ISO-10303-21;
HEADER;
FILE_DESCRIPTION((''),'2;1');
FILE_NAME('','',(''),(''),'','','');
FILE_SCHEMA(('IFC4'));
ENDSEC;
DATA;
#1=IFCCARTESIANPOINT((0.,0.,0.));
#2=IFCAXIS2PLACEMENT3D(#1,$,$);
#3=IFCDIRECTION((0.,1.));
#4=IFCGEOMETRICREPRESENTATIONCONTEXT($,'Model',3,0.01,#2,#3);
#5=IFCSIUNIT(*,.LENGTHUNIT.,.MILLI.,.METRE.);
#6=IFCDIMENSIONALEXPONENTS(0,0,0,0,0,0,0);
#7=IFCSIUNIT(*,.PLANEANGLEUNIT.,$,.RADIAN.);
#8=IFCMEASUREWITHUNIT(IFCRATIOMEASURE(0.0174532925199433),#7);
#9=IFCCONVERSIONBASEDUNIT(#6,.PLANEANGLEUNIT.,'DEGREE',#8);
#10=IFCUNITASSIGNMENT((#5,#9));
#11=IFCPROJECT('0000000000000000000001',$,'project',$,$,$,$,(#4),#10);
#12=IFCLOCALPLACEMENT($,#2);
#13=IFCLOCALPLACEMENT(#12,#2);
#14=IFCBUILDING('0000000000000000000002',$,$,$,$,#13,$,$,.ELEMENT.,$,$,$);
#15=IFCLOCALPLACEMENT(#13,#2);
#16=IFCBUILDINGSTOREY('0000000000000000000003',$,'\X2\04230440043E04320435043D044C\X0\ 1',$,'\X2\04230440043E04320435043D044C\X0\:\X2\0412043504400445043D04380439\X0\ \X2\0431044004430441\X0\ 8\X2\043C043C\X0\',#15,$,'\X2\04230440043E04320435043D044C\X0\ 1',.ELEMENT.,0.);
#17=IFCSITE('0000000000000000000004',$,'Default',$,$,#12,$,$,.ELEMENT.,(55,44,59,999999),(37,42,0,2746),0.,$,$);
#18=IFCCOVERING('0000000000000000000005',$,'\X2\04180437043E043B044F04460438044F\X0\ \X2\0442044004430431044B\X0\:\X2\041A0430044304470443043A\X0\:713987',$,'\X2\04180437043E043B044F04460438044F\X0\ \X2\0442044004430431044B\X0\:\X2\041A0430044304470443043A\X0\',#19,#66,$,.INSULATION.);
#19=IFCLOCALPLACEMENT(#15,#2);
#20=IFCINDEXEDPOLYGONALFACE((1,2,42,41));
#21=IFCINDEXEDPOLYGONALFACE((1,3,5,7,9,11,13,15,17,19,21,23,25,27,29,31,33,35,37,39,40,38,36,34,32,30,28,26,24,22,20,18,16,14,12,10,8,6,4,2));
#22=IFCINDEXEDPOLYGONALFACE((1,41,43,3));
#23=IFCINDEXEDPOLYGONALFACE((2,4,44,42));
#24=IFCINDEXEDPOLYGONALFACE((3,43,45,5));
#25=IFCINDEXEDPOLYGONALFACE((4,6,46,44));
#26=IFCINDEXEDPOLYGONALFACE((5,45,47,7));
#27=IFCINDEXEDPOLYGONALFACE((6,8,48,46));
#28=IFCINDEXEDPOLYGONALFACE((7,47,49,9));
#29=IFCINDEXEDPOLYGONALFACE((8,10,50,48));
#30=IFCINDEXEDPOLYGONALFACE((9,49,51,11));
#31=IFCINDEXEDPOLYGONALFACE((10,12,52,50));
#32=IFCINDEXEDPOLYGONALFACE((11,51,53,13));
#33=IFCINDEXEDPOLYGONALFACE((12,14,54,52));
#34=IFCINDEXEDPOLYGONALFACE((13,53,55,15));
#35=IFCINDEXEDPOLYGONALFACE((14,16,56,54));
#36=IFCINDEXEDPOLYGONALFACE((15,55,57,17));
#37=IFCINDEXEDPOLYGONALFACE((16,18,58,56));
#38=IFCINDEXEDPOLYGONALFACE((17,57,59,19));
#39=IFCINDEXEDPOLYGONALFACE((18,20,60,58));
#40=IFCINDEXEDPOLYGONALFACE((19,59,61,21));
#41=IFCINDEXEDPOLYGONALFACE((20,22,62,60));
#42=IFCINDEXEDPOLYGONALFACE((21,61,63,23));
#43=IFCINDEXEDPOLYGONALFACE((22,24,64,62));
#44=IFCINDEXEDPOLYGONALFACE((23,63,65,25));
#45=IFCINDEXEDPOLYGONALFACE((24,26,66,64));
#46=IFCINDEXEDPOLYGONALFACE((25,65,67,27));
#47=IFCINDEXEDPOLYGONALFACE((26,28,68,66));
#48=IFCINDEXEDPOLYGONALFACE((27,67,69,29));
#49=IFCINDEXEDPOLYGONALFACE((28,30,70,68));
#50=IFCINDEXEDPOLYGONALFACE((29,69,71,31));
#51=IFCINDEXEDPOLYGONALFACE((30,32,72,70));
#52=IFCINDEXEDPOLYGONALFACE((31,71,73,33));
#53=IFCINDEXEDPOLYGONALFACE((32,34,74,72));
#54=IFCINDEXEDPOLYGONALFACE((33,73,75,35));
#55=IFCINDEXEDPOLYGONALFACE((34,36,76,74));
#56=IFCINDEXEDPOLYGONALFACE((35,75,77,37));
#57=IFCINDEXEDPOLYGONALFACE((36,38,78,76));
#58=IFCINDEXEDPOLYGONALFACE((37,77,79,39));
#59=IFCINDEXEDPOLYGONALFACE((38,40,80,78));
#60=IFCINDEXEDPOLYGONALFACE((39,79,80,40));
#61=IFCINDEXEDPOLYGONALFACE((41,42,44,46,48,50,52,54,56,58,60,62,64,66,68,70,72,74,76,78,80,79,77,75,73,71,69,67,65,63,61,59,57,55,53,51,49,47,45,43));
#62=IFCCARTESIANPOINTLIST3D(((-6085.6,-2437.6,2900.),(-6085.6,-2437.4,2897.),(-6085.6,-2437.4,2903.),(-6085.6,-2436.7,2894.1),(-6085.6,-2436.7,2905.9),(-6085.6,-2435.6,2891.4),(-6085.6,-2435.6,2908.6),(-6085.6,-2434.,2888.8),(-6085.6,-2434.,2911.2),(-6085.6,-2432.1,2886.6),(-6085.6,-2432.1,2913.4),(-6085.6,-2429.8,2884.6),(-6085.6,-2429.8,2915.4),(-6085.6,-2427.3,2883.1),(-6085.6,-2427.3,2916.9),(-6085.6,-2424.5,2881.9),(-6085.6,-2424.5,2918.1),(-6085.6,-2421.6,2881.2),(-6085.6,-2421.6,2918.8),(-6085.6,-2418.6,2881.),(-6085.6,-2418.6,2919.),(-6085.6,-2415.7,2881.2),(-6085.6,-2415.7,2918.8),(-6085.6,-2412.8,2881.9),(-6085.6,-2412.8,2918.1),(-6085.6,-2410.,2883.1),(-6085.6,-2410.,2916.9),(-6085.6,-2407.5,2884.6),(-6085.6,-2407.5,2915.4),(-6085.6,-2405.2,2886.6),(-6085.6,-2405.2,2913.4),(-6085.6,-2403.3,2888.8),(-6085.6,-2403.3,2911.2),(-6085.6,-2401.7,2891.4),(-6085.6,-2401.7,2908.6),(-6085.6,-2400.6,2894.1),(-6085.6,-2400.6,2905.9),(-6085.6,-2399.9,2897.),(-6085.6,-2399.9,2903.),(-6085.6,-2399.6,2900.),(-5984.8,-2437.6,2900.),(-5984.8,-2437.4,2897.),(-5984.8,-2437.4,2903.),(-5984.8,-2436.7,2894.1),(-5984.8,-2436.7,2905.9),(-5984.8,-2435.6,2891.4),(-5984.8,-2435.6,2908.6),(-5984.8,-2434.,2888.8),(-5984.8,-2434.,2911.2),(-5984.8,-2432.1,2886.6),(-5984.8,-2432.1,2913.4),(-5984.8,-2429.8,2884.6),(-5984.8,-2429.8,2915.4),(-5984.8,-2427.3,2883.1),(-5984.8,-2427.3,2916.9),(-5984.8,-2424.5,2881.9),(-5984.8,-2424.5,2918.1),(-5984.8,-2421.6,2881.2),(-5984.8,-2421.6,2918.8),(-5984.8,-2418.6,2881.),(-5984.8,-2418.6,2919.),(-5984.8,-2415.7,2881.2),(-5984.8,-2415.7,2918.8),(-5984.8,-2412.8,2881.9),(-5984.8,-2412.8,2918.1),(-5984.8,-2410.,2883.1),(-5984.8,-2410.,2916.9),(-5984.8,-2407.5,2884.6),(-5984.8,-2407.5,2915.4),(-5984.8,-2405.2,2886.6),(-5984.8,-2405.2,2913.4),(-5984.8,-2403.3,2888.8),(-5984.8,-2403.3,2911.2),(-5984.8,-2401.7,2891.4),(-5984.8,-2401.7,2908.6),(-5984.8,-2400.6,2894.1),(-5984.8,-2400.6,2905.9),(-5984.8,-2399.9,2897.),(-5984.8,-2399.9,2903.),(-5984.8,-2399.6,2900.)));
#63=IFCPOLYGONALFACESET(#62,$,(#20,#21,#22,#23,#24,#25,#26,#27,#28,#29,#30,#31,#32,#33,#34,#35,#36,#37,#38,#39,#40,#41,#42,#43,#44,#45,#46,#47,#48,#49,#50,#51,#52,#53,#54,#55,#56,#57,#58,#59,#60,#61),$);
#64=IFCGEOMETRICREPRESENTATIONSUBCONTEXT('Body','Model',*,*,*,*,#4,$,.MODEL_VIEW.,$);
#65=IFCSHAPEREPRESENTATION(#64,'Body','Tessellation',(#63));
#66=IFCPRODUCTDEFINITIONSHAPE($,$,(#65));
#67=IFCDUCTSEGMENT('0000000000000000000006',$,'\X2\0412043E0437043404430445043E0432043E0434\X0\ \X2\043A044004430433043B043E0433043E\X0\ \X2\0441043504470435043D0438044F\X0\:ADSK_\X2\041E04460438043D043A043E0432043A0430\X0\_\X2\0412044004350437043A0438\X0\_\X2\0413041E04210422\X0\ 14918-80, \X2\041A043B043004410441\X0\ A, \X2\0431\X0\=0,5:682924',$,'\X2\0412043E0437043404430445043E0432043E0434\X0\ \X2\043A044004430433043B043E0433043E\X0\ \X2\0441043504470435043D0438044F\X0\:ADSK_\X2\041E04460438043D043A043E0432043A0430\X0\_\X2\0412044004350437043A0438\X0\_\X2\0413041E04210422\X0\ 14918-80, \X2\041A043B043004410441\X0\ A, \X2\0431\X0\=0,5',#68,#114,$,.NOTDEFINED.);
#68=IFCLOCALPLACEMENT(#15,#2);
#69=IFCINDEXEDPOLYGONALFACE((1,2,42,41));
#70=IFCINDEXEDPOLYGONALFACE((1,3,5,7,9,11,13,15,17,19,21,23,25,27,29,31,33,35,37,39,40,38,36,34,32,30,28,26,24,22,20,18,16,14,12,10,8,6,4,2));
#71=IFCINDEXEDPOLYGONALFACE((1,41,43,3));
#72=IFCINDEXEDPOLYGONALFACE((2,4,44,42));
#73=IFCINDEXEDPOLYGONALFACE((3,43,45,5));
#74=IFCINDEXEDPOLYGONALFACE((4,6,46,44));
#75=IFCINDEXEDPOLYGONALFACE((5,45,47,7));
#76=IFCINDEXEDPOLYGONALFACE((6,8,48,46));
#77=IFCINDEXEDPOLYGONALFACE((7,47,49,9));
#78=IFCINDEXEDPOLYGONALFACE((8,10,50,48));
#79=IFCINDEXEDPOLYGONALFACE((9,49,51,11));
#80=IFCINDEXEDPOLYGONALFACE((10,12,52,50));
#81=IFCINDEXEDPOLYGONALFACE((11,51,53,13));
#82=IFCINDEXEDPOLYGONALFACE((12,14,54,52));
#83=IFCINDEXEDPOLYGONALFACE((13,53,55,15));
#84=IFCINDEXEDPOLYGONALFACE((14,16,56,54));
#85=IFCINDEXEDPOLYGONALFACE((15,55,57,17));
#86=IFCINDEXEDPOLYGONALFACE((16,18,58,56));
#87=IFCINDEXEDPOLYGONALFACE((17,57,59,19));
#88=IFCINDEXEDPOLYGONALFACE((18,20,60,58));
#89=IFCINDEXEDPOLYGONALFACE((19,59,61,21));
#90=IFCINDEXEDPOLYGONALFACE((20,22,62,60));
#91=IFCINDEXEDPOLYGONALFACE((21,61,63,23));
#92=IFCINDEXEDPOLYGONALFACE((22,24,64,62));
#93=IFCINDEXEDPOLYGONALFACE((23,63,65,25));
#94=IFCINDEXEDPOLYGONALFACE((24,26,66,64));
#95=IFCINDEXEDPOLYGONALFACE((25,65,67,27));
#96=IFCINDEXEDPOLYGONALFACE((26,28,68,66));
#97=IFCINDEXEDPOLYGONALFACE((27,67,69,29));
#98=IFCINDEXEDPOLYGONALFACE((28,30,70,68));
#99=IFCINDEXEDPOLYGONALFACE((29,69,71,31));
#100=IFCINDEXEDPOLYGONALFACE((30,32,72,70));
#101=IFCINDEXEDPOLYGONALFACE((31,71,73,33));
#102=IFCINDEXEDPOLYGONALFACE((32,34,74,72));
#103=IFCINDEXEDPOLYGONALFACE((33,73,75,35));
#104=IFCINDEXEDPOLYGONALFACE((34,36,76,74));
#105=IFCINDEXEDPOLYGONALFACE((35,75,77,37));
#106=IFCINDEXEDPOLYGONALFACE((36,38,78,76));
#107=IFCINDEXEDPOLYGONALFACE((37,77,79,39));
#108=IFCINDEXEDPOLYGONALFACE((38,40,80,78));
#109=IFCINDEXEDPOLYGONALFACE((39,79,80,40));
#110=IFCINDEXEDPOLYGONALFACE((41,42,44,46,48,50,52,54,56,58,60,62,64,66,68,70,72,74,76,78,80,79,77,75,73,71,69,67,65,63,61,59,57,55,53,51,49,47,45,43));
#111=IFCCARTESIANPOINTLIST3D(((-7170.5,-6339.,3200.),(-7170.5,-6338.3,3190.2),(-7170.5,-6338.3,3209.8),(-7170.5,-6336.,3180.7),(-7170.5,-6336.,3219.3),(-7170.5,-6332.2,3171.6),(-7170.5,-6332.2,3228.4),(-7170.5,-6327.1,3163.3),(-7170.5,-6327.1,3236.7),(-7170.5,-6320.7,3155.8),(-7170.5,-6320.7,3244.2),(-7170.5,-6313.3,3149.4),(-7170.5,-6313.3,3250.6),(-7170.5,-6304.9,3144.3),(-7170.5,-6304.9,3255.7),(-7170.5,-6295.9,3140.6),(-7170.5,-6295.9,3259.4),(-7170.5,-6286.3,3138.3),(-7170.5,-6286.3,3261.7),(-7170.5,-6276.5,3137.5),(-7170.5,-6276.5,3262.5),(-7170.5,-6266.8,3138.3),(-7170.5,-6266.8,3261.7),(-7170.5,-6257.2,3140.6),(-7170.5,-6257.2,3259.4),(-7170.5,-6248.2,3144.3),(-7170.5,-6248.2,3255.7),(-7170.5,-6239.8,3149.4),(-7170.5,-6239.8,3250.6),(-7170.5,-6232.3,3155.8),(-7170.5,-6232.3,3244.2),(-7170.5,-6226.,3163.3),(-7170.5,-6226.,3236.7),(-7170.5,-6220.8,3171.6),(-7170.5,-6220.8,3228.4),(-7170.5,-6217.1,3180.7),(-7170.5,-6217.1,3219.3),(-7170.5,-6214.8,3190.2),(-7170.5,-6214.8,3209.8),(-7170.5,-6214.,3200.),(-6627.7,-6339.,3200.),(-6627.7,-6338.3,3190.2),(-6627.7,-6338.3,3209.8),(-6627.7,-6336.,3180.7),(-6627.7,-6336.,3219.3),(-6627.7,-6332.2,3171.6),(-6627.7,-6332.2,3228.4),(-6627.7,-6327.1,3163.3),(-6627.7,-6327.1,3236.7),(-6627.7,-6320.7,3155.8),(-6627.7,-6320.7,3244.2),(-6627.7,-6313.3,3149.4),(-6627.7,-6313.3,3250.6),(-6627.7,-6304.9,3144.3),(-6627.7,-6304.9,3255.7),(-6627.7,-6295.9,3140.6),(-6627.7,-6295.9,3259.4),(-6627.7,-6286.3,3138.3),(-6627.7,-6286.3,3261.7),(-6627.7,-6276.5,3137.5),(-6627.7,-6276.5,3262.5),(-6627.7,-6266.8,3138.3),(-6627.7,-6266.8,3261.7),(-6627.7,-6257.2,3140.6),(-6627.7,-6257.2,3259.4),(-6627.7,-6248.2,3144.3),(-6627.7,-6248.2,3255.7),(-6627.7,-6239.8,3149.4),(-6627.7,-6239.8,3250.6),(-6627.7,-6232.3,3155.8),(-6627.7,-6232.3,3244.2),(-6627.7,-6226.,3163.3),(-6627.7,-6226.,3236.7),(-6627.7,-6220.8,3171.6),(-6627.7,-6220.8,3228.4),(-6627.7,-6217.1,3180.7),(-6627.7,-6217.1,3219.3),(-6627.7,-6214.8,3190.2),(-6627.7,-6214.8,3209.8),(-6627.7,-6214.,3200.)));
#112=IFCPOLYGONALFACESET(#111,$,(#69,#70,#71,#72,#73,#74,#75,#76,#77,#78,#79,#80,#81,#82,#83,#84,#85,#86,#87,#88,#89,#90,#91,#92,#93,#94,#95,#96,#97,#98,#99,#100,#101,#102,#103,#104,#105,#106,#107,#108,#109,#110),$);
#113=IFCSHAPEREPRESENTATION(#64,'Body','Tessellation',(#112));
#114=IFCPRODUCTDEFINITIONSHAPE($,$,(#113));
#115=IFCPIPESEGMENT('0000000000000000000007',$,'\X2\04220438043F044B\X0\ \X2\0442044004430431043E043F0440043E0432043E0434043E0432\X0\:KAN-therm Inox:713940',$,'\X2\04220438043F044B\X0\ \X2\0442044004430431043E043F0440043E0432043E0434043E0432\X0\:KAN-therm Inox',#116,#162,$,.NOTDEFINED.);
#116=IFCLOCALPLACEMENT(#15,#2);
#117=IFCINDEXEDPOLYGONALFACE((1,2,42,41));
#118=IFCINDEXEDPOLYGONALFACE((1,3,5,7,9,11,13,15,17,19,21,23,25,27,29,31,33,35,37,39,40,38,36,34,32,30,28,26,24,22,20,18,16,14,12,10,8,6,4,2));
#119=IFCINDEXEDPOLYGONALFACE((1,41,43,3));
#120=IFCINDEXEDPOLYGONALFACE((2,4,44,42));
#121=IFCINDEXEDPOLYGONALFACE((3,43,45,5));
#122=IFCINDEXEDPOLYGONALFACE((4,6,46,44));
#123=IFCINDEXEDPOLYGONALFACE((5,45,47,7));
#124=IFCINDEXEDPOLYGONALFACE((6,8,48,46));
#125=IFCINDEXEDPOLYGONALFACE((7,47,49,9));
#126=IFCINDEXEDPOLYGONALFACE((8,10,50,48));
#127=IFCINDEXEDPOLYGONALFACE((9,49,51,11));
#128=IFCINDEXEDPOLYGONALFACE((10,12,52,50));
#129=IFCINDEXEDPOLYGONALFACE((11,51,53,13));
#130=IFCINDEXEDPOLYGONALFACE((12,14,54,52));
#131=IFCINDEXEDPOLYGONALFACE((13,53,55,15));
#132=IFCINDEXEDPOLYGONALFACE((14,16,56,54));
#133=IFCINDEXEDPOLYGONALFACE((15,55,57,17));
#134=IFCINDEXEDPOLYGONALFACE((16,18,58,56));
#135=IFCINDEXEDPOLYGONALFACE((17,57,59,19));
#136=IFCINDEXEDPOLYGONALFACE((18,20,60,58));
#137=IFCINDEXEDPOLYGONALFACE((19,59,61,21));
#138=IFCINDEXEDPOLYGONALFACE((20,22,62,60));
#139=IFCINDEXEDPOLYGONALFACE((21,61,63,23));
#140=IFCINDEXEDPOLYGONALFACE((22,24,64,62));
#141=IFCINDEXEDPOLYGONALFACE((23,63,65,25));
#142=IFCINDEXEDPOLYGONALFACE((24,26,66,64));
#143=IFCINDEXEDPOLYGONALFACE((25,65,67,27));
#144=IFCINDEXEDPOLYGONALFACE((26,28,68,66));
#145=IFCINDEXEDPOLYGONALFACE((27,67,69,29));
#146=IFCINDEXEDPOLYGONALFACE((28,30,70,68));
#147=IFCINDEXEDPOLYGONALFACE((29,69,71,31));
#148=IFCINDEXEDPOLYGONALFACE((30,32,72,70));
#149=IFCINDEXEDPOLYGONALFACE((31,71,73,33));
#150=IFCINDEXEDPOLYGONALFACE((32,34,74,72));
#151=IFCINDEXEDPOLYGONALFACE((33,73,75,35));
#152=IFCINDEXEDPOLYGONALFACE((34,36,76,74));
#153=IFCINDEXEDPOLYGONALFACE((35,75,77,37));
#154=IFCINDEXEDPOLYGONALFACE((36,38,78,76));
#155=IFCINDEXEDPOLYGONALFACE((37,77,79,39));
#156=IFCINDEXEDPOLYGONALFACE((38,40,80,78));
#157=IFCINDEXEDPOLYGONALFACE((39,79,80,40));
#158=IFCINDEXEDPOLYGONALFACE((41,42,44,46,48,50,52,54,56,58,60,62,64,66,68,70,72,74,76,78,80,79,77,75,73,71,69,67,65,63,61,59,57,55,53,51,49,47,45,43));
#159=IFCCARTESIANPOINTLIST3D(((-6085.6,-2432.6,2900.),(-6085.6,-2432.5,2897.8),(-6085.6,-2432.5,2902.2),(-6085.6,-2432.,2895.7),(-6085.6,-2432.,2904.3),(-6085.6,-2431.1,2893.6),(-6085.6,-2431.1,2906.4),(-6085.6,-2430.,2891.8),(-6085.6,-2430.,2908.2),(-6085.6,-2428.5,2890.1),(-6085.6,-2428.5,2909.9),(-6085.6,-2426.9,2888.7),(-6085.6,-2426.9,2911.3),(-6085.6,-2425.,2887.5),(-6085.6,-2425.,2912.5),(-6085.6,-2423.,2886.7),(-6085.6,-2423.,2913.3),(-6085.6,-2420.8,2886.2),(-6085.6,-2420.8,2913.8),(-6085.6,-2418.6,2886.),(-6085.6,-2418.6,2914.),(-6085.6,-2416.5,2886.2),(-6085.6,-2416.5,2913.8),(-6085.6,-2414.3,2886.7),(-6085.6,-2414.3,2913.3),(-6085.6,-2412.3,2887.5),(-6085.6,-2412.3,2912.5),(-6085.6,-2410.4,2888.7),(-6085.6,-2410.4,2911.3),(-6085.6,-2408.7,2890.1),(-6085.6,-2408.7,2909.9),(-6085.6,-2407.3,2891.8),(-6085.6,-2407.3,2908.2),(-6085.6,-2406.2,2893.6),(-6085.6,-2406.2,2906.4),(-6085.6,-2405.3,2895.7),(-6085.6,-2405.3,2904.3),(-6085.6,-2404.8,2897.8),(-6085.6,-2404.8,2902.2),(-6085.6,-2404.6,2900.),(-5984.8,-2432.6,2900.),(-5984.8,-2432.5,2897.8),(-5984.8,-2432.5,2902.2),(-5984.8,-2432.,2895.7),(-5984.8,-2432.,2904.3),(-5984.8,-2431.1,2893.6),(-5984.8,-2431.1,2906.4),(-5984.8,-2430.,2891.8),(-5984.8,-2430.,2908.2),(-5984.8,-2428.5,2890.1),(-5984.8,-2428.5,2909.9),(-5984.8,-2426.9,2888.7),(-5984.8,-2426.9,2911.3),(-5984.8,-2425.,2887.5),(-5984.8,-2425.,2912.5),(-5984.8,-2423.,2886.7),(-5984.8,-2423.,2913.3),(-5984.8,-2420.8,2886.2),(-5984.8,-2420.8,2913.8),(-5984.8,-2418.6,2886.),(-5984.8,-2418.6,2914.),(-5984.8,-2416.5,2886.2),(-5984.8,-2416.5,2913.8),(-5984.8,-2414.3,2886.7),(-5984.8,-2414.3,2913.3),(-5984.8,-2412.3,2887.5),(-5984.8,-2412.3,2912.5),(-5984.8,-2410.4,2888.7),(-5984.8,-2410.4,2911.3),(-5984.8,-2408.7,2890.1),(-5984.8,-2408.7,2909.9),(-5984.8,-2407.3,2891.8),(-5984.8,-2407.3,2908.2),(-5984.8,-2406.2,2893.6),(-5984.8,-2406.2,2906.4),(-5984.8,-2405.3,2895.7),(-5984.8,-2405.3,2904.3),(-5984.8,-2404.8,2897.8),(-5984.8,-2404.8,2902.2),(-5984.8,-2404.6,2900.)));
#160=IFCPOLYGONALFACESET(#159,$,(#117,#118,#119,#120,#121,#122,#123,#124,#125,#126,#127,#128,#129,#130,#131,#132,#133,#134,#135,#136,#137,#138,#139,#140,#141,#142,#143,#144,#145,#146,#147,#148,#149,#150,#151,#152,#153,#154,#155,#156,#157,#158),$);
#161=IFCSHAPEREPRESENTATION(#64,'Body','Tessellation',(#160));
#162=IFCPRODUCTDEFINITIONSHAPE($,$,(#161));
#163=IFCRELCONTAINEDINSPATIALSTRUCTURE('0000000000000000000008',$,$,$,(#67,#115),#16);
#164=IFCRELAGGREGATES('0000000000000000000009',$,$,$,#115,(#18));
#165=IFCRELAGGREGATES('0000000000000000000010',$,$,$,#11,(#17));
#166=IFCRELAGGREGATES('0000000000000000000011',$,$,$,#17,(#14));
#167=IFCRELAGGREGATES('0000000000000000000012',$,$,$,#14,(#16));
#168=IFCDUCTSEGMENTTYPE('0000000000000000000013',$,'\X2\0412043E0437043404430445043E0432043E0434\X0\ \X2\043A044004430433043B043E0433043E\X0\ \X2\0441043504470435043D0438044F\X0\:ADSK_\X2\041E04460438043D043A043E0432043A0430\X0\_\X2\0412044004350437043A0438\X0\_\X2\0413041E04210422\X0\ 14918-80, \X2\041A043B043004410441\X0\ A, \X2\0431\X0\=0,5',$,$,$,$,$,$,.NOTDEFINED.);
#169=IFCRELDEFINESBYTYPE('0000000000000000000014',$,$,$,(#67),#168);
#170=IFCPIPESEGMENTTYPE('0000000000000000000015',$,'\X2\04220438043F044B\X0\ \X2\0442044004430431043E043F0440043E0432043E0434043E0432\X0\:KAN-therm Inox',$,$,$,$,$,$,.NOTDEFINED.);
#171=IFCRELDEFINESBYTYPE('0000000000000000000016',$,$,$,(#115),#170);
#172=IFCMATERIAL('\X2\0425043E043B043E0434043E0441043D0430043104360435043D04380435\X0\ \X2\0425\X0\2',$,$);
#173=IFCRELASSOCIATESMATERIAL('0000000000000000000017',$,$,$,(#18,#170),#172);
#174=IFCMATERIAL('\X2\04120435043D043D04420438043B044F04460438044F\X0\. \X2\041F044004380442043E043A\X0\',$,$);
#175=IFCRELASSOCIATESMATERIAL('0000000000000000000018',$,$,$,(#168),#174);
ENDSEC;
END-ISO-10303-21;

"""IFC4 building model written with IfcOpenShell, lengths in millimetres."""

from ifc_helpers import new_model, entity, si_unit, converted_unit, direction, frame, origin, place, context, subcontext, project, spatial, indexed_curve, outline, extrude, material, type_object, element, aggregate, save


model = new_model("IFC4")

# Units and contexts
model_context = context("Model", 3, precision=0.01, world=origin(), true_north=direction((0.0, 1.0)))
body_context = subcontext(model_context, "Body", "Model", "MODEL_VIEW")
ifc_project = project(units=[si_unit("LENGTHUNIT", "METRE", prefix="MILLI"), converted_unit("PLANEANGLEUNIT", "DEGREE", entity("IfcRatioMeasure", 0.0174532925199433), si_unit("PLANEANGLEUNIT", "RADIAN"), dimensions=[0, 0, 0, 0, 0, 0, 0])], contexts=[model_context])

# Site, building, storey
site_placement = place(None, origin())
site = spatial("IfcSite", under=ifc_project, at=site_placement, Name="Default", CompositionType="ELEMENT", RefLatitude=(55, 44, 59, 999999), RefLongitude=(37, 42, 0, 2746), RefElevation=0.0)
building_placement = place(site_placement, origin())
building = spatial("IfcBuilding", under=site, at=building_placement, CompositionType="ELEMENT")
storey_placement = place(building_placement, origin())
storey = spatial("IfcBuildingStorey", under=building, at=storey_placement, Name="Уровень 1", ObjectType="Уровень:Верхний брус 8мм", LongName="Уровень 1", CompositionType="ELEMENT", Elevation=0.0)

# Covering
ifc_material_1 = material(Name="Холодоснабжение Х2")
covering_1_placement = place(storey_placement, origin())
covering_1 = element("IfcCovering", 1, at=covering_1_placement, material=ifc_material_1, Name="Изоляция трубы:Каучук:713987", ObjectType="Изоляция трубы:Каучук", PredefinedType="INSULATION", context=body_context, shape_type="SweptSolid", body=[
    extrude(outline(indexed_curve([(19.0, 0.0), (18.8, 3.0), (18.1, 5.9), (16.9, 8.6), (15.4, 11.2), (13.4, 13.4), (11.2, 15.4), (8.6, 16.9), (5.9, 18.1), (3.0, 18.8), (0.0, 19.0), (-3.0, 18.8), (-5.9, 18.1), (-8.6, 16.9), (-11.2, 15.4), (-13.4, 13.4), (-15.4, 11.2), (-16.9, 8.6), (-18.1, 5.9), (-18.8, 3.0), (-19.0, 0.0), (-18.8, -3.0), (-18.1, -5.9), (-16.9, -8.6), (-15.4, -11.2), (-13.4, -13.4), (-11.2, -15.4), (-8.6, -16.9), (-5.9, -18.1), (-3.0, -18.8), (0.0, -19.0), (3.0, -18.8), (5.9, -18.1), (8.6, -16.9), (11.2, -15.4), (13.4, -13.4), (15.4, -11.2), (16.9, -8.6), (18.1, -5.9), (18.8, -3.0), (19.0, 0.0)], self_intersect=False)), frame((-6085.6, -2418.6, 2900.0), z_axis=(1.0, 0.0, 0.0), x_axis=(0.0, -1.0, 0.0)), (0.0, 0.0, 1.0), 100.8),
])

# Duct segment
ifc_material_2 = material(Name="Веннтиляция. Приток")
duct_segment_type = type_object("IfcDuctSegmentType", Name="Воздуховод круглого сечения:ADSK_Оцинковка_Врезки_ГОСТ 14918-80, Класс A, б=0,5", PredefinedType="NOTDEFINED", material=ifc_material_2)
duct_segment_1_placement = place(storey_placement, origin())
element("IfcDuctSegment", 2, at=duct_segment_1_placement, inside=storey, type_object=duct_segment_type, Name="Воздуховод круглого сечения:ADSK_Оцинковка_Врезки_ГОСТ 14918-80, Класс A, б=0,5:682924", ObjectType="Воздуховод круглого сечения:ADSK_Оцинковка_Врезки_ГОСТ 14918-80, Класс A, б=0,5", PredefinedType="NOTDEFINED", context=body_context, shape_type="SweptSolid", body=[
    extrude(outline(indexed_curve([(62.5, 0.0), (61.7, 9.8), (59.4, 19.3), (55.7, 28.4), (50.6, 36.7), (44.2, 44.2), (36.7, 50.6), (28.4, 55.7), (19.3, 59.4), (9.8, 61.7), (0.0, 62.5), (-9.8, 61.7), (-19.3, 59.4), (-28.4, 55.7), (-36.7, 50.6), (-44.2, 44.2), (-50.6, 36.7), (-55.7, 28.4), (-59.4, 19.3), (-61.7, 9.8), (-62.5, 0.0), (-61.7, -9.8), (-59.4, -19.3), (-55.7, -28.4), (-50.6, -36.7), (-44.2, -44.2), (-36.7, -50.6), (-28.4, -55.7), (-19.3, -59.4), (-9.8, -61.7), (0.0, -62.5), (9.8, -61.7), (19.3, -59.4), (28.4, -55.7), (36.7, -50.6), (44.2, -44.2), (50.6, -36.7), (55.7, -28.4), (59.4, -19.3), (61.7, -9.8), (62.5, 0.0)], self_intersect=False)), frame((-7170.5, -6276.5, 3200.0), z_axis=(1.0, 0.0, 0.0), x_axis=(0.0, -1.0, 0.0)), (0.0, 0.0, 1.0), 542.8),
])

# Pipe segment
pipe_segment_type_1 = type_object("IfcPipeSegmentType", Name="Типы трубопроводов:KAN-therm Inox", PredefinedType="NOTDEFINED", material=ifc_material_1)
pipe_segment_1_placement = place(storey_placement, origin())
pipe_segment_1 = element("IfcPipeSegment", 3, at=pipe_segment_1_placement, inside=storey, type_object=pipe_segment_type_1, Name="Типы трубопроводов:KAN-therm Inox:713940", ObjectType="Типы трубопроводов:KAN-therm Inox", PredefinedType="NOTDEFINED", context=body_context, shape_type="SweptSolid", body=[
    extrude(outline(indexed_curve([(14.0, 0.0), (13.8, 2.2), (13.3, 4.3), (12.5, 6.4), (11.3, 8.2), (9.9, 9.9), (8.2, 11.3), (6.4, 12.5), (4.3, 13.3), (2.2, 13.8), (0.0, 14.0), (-2.2, 13.8), (-4.3, 13.3), (-6.4, 12.5), (-8.2, 11.3), (-9.9, 9.9), (-11.3, 8.2), (-12.5, 6.4), (-13.3, 4.3), (-13.8, 2.2), (-14.0, 0.0), (-13.8, -2.2), (-13.3, -4.3), (-12.5, -6.4), (-11.3, -8.2), (-9.9, -9.9), (-8.2, -11.3), (-6.4, -12.5), (-4.3, -13.3), (-2.2, -13.8), (0.0, -14.0), (2.2, -13.8), (4.3, -13.3), (6.4, -12.5), (8.2, -11.3), (9.9, -9.9), (11.3, -8.2), (12.5, -6.4), (13.3, -4.3), (13.8, -2.2), (14.0, 0.0)], self_intersect=False)), frame((-6085.6, -2418.6, 2900.0), z_axis=(1.0, 0.0, 0.0), x_axis=(0.0, 1.0, 0.0)), (0.0, 0.0, 1.0), 100.8),
])
aggregate(pipe_segment_1, [covering_1])

save(model, "model.ifc")
